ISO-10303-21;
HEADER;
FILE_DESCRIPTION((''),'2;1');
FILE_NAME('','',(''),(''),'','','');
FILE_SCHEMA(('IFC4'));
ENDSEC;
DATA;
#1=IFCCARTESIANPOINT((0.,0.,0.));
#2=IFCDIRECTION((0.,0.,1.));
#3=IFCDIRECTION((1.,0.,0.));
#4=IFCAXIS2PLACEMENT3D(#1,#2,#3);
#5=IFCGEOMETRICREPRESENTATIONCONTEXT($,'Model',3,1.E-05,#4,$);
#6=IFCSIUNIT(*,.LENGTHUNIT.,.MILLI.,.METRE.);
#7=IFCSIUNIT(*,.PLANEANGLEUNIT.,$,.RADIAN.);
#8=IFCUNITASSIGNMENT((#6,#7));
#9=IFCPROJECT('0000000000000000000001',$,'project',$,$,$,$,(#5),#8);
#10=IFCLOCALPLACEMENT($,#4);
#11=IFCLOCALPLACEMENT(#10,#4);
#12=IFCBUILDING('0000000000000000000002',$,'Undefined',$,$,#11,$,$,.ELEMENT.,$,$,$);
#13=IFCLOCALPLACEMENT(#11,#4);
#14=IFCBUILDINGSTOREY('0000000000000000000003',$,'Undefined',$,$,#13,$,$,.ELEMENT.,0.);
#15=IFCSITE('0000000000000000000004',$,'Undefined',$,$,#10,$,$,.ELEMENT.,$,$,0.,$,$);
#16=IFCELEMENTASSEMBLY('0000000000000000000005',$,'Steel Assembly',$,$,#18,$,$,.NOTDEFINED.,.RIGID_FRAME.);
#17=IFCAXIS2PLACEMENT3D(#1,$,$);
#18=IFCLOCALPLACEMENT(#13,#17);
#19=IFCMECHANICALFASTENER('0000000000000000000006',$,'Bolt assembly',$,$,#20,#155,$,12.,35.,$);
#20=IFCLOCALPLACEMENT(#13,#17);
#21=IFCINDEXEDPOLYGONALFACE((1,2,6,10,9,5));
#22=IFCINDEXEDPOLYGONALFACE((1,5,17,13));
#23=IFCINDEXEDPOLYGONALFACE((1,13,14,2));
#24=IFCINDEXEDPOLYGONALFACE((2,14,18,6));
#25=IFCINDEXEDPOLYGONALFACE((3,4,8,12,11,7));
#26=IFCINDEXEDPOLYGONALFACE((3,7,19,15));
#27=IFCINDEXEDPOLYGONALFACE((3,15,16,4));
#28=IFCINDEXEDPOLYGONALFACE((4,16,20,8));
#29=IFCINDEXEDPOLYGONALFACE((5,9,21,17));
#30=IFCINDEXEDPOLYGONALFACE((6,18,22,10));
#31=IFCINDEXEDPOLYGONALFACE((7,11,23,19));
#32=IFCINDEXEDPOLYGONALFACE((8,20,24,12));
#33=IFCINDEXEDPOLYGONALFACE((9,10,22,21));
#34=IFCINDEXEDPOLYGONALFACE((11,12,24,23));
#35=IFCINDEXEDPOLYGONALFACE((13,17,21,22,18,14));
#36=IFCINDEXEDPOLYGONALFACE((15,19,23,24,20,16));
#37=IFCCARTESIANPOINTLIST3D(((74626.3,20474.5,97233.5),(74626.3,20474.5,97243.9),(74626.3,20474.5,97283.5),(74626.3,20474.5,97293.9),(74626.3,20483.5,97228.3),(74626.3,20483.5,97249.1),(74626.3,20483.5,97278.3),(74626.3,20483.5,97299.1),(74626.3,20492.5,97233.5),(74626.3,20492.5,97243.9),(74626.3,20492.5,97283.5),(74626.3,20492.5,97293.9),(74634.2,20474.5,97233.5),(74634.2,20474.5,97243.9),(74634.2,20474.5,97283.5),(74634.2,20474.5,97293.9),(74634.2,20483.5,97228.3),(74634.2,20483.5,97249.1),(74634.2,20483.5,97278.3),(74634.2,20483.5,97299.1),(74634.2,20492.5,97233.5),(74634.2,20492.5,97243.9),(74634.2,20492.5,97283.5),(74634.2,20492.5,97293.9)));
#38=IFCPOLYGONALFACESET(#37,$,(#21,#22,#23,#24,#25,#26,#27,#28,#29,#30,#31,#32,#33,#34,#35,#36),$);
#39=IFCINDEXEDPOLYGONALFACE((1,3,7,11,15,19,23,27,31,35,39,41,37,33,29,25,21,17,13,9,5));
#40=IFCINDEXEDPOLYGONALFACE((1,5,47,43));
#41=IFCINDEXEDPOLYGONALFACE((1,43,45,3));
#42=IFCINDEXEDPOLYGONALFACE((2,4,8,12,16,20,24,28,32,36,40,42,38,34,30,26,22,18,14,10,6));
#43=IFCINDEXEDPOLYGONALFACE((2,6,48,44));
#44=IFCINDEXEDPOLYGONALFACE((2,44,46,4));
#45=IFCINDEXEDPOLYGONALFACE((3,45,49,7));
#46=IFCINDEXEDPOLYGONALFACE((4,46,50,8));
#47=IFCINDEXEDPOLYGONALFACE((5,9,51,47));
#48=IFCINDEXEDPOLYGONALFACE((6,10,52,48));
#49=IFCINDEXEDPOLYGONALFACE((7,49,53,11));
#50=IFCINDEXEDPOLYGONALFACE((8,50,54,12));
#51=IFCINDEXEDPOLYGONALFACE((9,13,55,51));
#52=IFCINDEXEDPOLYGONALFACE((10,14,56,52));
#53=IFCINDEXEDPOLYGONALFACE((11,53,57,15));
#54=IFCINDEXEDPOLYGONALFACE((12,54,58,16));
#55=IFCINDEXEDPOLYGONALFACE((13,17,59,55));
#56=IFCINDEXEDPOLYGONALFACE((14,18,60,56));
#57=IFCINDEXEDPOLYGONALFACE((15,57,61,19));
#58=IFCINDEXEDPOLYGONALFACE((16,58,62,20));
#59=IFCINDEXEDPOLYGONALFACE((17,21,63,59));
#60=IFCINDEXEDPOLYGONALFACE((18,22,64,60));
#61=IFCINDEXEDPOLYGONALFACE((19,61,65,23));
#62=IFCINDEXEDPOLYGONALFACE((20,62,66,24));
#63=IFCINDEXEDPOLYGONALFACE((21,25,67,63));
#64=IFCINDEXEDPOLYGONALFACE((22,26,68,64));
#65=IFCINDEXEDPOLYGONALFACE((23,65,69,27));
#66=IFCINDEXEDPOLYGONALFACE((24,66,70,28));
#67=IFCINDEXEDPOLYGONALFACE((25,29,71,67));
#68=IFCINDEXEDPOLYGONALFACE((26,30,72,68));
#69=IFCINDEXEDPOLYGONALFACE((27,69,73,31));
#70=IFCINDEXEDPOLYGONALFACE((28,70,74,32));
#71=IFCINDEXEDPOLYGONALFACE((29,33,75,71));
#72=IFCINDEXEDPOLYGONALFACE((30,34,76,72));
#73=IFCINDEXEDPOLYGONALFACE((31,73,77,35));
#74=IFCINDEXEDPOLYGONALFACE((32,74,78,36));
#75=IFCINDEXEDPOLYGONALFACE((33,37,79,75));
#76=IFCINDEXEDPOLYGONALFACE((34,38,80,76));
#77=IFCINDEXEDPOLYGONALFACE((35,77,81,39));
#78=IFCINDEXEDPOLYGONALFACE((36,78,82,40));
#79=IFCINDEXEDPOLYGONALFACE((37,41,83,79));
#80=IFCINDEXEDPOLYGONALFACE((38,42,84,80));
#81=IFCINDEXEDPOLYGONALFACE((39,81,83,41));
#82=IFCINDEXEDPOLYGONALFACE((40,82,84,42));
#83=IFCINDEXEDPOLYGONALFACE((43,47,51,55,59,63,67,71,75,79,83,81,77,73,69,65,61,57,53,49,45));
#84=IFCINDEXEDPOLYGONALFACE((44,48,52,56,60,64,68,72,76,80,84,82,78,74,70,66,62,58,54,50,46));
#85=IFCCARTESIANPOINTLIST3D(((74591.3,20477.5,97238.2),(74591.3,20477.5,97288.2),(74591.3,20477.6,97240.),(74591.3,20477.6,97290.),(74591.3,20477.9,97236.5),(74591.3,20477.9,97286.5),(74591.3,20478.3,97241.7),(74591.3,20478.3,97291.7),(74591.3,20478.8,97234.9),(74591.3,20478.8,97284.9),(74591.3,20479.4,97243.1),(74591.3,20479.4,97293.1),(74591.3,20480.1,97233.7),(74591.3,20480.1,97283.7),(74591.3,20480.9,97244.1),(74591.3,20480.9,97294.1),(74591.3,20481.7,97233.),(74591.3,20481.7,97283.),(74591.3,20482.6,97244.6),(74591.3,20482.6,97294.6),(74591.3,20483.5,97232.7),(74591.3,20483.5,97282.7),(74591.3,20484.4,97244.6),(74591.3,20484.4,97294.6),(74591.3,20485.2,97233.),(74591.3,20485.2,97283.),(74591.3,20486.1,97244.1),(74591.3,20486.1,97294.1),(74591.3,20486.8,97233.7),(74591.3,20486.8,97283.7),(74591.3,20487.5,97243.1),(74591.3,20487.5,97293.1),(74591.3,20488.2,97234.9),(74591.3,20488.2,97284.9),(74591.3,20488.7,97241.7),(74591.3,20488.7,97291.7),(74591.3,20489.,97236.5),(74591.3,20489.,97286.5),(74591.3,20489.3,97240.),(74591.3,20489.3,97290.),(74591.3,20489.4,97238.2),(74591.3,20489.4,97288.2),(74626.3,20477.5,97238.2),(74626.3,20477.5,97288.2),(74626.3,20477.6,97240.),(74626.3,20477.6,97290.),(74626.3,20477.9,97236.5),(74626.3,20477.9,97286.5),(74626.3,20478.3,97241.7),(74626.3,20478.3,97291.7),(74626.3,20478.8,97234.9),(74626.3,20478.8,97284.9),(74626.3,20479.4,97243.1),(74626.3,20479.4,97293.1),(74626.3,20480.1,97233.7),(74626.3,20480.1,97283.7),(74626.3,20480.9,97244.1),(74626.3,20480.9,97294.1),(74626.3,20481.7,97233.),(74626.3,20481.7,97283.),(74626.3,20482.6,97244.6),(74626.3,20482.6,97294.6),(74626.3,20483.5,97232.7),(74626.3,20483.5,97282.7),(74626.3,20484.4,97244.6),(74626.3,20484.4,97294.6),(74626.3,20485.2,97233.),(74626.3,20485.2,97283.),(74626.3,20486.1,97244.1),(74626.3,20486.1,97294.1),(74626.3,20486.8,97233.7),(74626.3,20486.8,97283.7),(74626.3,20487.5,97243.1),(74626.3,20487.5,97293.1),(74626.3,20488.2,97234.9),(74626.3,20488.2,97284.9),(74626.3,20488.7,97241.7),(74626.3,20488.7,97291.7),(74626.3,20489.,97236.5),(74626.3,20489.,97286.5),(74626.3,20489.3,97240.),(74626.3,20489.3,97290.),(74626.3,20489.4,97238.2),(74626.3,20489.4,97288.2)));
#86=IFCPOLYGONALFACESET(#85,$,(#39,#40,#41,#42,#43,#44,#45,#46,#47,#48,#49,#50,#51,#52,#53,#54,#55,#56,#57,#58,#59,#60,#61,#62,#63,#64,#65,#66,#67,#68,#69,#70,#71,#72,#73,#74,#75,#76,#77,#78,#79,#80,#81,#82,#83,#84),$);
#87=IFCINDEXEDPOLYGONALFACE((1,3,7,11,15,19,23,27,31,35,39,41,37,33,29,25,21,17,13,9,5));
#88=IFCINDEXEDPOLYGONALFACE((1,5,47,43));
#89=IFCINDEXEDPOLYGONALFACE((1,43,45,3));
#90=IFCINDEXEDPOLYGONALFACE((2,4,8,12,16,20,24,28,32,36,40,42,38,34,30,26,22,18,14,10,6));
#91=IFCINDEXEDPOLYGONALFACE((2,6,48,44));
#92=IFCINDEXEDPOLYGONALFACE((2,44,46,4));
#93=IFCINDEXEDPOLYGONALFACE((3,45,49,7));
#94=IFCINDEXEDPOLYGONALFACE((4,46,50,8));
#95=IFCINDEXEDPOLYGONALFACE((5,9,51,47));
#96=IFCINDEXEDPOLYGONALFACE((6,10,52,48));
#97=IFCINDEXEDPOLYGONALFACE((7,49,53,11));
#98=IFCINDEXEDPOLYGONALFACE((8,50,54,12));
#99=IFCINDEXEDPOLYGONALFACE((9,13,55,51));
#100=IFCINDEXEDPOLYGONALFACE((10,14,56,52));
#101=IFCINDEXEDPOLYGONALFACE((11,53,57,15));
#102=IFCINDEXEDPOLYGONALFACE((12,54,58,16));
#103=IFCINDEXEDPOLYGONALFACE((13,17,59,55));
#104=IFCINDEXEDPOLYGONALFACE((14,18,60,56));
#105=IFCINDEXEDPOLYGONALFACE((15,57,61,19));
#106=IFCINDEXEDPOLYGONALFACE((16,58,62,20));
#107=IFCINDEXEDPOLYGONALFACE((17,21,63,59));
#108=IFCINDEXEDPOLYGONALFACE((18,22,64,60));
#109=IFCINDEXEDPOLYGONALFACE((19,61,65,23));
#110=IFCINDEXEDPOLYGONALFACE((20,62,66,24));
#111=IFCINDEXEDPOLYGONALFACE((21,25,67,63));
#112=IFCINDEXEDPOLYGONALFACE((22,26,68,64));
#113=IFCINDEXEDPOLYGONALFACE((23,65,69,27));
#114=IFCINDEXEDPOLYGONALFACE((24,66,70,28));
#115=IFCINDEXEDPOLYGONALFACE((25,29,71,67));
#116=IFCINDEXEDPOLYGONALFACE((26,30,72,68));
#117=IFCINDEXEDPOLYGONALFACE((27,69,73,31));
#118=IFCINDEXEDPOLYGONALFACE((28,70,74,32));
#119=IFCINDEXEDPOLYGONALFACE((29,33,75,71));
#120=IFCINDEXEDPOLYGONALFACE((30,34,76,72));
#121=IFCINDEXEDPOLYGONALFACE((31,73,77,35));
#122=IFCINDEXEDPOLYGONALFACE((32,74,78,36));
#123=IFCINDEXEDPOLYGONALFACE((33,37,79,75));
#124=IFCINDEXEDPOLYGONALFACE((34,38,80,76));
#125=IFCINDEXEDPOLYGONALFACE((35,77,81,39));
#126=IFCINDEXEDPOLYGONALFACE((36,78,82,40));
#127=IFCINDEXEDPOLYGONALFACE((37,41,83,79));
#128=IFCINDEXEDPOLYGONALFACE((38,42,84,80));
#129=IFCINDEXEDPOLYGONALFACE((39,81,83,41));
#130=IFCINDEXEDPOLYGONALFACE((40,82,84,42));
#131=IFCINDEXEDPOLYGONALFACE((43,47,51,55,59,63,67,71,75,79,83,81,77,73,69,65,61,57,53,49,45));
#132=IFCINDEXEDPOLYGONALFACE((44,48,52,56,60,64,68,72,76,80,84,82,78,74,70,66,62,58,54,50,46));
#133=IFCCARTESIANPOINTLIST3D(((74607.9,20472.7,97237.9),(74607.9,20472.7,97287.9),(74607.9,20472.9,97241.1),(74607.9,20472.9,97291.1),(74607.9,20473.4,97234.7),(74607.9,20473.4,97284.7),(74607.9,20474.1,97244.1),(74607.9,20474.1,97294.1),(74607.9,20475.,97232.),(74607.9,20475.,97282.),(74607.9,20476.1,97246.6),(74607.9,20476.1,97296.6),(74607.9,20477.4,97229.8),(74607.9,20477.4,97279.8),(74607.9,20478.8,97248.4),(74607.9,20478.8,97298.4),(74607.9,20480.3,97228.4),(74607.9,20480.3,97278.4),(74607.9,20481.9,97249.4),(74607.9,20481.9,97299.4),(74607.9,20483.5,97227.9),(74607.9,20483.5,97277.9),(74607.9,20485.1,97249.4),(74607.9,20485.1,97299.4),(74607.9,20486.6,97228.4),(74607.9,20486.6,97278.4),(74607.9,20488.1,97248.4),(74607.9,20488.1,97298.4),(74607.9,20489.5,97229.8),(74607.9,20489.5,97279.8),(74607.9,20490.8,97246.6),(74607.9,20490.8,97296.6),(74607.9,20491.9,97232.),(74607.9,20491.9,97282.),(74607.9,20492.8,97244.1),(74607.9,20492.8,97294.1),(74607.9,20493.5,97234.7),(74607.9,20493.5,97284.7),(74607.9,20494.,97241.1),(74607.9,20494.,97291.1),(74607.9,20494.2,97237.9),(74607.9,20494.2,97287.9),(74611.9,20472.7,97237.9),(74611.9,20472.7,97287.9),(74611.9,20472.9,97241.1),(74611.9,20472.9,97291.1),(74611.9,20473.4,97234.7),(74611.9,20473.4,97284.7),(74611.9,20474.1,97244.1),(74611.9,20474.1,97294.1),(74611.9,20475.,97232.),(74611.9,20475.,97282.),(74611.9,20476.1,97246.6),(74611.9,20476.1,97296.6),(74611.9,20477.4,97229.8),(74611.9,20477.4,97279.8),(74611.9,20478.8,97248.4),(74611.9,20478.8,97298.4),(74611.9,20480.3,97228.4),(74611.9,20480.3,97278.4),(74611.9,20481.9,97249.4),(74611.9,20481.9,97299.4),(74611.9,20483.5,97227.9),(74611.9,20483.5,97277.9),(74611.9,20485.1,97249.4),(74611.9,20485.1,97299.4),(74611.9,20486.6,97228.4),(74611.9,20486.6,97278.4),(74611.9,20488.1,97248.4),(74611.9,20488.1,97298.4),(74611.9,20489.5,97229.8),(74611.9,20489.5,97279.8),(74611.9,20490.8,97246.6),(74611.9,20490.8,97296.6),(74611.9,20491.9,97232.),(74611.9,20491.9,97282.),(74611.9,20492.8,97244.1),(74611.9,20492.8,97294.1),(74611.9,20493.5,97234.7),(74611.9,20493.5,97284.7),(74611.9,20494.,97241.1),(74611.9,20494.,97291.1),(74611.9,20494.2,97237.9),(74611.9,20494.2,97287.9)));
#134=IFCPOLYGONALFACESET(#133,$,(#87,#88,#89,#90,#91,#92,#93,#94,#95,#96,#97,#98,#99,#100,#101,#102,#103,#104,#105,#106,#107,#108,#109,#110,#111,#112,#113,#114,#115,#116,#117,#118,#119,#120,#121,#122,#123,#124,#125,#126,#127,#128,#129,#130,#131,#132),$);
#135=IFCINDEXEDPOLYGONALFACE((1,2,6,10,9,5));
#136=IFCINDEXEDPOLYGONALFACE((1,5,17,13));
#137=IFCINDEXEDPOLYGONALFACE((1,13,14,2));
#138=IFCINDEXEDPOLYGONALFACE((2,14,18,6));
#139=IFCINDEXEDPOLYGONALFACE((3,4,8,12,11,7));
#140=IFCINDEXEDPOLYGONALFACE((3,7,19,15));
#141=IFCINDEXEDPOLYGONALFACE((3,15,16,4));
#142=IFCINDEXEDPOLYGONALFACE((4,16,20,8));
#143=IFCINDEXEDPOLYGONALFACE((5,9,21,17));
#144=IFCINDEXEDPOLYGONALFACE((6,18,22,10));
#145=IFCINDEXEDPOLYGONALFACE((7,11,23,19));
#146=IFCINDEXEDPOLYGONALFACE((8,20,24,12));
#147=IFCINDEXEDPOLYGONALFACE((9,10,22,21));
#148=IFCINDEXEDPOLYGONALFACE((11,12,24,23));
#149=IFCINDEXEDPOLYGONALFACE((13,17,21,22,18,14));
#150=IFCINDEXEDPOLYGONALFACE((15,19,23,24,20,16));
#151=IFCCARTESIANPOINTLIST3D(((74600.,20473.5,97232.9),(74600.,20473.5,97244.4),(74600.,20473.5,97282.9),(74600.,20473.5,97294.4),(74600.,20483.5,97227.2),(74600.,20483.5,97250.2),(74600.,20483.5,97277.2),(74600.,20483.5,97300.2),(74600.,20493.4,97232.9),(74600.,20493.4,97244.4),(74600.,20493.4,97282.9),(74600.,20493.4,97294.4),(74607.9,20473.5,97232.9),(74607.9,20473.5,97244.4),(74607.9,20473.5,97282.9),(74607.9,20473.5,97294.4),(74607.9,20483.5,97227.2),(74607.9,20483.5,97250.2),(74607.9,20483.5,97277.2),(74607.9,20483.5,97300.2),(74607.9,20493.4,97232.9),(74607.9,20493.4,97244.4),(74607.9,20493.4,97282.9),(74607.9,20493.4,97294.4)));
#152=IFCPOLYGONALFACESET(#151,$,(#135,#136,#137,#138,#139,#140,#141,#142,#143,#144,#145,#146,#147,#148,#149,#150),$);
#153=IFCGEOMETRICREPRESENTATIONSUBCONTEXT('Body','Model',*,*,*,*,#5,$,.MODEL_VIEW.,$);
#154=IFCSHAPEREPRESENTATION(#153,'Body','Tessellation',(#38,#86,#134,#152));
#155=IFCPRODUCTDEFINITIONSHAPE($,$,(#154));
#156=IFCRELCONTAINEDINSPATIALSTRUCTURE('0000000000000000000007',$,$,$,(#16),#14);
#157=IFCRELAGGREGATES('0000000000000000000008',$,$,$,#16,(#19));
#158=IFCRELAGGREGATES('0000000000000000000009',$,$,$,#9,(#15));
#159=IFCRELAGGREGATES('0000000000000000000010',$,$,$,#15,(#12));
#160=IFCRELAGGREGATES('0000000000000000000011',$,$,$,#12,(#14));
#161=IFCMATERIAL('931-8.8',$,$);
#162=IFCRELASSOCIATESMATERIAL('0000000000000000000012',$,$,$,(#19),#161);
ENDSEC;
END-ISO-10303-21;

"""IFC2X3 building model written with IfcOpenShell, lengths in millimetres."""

from ifc_helpers import new_model, si_unit, frame, origin_with_axes, origin_2d_with_axis, place, context, subcontext, project, spatial, polyline, circle, outline, extrude, source, transform, mapped, material, element, aggregate, save


model = new_model("IFC2X3")

# Units and contexts
model_context = context("Model", 3, precision=1e-05, world=origin_with_axes())
body_context = subcontext(model_context, "Body", "Model", "MODEL_VIEW")
ifc_project = project(units=[si_unit("LENGTHUNIT", "METRE", prefix="MILLI"), si_unit("PLANEANGLEUNIT", "RADIAN")], contexts=[model_context])

# Site, building, storey
site_placement = place(None, origin_with_axes())
site = spatial("IfcSite", under=ifc_project, at=site_placement, Name="Undefined", CompositionType="ELEMENT", RefElevation=0.0)
building_placement = place(site_placement, origin_with_axes())
building = spatial("IfcBuilding", under=site, at=building_placement, Name="Undefined", CompositionType="ELEMENT")
storey_placement = place(building_placement, origin_with_axes())
storey = spatial("IfcBuildingStorey", under=building, at=storey_placement, Name="Undefined", CompositionType="ELEMENT", Elevation=0.0)

# Shared definitions
ifc_material_1 = material(Name="931-8.8")

# Element assembly
assembly_1_placement = place(storey_placement, origin_with_axes())
assembly_1 = element("IfcElementAssembly", 1, at=assembly_1_placement, inside=storey, Name="Steel Assembly", AssemblyPlace="NOTDEFINED", PredefinedType="RIGID_FRAME")
shared_shape_1 = source(origin_with_axes(), body_context, "Body", "SweptSolid", [
    extrude(outline(polyline([(10.4, 0.0), (5.2, 9.0), (-5.2, 9.0), (-10.4, 0.0), (-5.2, -9.0), (5.2, -9.0), (10.4, 0.0)])), frame((0.0, -22.3, 0.0), z_axis=(0.0, 1.0, 0.0), x_axis=(1.0, 0.0, 0.0)), (0.0, 0.0, 1.0), 7.9),
    extrude(circle(Radius=6.0, at=origin_2d_with_axis()), frame((0.0, -14.4, 0.0), z_axis=(0.0, 1.0, 0.0), x_axis=(1.0, 0.0, 0.0)), (0.0, 0.0, 1.0), 35.0),
    extrude(circle(Radius=10.8, at=origin_2d_with_axis()), frame((0.0, 0.0, 0.0), z_axis=(0.0, 1.0, 0.0), x_axis=(1.0, 0.0, 0.0)), (0.0, 0.0, 1.0), 4.0),
    extrude(outline(polyline([(11.5, 0.0), (5.8, 10.0), (-5.8, 10.0), (-11.5, 0.0), (-5.8, -10.0), (5.8, -10.0), (11.5, 0.0)])), frame((0.0, 4.0, 0.0), z_axis=(0.0, 1.0, 0.0), x_axis=(1.0, 0.0, 0.0)), (0.0, 0.0, 1.0), 7.9),
])

# Mechanical fastener
mechanical_fastener_1_placement = place(assembly_1_placement, frame((74611.9, 20483.5, 97288.7), z_axis=(0.0, 1.0, 0.0), x_axis=(0.0, 0.0, -1.0)))
mechanical_fastener_1 = element("IfcMechanicalFastener", 2, at=mechanical_fastener_1_placement, material=ifc_material_1, Name="Bolt assembly", NominalDiameter=12.0, NominalLength=35.0, context=body_context, shape_type="MappedRepresentation", body=[
    mapped(shared_shape_1, transform((0.0, 0.0, 0.0))),
    mapped(shared_shape_1, transform((50.0, 0.0, 0.0))),
])
aggregate(assembly_1, [mechanical_fastener_1])

save(model, "model.ifc")
